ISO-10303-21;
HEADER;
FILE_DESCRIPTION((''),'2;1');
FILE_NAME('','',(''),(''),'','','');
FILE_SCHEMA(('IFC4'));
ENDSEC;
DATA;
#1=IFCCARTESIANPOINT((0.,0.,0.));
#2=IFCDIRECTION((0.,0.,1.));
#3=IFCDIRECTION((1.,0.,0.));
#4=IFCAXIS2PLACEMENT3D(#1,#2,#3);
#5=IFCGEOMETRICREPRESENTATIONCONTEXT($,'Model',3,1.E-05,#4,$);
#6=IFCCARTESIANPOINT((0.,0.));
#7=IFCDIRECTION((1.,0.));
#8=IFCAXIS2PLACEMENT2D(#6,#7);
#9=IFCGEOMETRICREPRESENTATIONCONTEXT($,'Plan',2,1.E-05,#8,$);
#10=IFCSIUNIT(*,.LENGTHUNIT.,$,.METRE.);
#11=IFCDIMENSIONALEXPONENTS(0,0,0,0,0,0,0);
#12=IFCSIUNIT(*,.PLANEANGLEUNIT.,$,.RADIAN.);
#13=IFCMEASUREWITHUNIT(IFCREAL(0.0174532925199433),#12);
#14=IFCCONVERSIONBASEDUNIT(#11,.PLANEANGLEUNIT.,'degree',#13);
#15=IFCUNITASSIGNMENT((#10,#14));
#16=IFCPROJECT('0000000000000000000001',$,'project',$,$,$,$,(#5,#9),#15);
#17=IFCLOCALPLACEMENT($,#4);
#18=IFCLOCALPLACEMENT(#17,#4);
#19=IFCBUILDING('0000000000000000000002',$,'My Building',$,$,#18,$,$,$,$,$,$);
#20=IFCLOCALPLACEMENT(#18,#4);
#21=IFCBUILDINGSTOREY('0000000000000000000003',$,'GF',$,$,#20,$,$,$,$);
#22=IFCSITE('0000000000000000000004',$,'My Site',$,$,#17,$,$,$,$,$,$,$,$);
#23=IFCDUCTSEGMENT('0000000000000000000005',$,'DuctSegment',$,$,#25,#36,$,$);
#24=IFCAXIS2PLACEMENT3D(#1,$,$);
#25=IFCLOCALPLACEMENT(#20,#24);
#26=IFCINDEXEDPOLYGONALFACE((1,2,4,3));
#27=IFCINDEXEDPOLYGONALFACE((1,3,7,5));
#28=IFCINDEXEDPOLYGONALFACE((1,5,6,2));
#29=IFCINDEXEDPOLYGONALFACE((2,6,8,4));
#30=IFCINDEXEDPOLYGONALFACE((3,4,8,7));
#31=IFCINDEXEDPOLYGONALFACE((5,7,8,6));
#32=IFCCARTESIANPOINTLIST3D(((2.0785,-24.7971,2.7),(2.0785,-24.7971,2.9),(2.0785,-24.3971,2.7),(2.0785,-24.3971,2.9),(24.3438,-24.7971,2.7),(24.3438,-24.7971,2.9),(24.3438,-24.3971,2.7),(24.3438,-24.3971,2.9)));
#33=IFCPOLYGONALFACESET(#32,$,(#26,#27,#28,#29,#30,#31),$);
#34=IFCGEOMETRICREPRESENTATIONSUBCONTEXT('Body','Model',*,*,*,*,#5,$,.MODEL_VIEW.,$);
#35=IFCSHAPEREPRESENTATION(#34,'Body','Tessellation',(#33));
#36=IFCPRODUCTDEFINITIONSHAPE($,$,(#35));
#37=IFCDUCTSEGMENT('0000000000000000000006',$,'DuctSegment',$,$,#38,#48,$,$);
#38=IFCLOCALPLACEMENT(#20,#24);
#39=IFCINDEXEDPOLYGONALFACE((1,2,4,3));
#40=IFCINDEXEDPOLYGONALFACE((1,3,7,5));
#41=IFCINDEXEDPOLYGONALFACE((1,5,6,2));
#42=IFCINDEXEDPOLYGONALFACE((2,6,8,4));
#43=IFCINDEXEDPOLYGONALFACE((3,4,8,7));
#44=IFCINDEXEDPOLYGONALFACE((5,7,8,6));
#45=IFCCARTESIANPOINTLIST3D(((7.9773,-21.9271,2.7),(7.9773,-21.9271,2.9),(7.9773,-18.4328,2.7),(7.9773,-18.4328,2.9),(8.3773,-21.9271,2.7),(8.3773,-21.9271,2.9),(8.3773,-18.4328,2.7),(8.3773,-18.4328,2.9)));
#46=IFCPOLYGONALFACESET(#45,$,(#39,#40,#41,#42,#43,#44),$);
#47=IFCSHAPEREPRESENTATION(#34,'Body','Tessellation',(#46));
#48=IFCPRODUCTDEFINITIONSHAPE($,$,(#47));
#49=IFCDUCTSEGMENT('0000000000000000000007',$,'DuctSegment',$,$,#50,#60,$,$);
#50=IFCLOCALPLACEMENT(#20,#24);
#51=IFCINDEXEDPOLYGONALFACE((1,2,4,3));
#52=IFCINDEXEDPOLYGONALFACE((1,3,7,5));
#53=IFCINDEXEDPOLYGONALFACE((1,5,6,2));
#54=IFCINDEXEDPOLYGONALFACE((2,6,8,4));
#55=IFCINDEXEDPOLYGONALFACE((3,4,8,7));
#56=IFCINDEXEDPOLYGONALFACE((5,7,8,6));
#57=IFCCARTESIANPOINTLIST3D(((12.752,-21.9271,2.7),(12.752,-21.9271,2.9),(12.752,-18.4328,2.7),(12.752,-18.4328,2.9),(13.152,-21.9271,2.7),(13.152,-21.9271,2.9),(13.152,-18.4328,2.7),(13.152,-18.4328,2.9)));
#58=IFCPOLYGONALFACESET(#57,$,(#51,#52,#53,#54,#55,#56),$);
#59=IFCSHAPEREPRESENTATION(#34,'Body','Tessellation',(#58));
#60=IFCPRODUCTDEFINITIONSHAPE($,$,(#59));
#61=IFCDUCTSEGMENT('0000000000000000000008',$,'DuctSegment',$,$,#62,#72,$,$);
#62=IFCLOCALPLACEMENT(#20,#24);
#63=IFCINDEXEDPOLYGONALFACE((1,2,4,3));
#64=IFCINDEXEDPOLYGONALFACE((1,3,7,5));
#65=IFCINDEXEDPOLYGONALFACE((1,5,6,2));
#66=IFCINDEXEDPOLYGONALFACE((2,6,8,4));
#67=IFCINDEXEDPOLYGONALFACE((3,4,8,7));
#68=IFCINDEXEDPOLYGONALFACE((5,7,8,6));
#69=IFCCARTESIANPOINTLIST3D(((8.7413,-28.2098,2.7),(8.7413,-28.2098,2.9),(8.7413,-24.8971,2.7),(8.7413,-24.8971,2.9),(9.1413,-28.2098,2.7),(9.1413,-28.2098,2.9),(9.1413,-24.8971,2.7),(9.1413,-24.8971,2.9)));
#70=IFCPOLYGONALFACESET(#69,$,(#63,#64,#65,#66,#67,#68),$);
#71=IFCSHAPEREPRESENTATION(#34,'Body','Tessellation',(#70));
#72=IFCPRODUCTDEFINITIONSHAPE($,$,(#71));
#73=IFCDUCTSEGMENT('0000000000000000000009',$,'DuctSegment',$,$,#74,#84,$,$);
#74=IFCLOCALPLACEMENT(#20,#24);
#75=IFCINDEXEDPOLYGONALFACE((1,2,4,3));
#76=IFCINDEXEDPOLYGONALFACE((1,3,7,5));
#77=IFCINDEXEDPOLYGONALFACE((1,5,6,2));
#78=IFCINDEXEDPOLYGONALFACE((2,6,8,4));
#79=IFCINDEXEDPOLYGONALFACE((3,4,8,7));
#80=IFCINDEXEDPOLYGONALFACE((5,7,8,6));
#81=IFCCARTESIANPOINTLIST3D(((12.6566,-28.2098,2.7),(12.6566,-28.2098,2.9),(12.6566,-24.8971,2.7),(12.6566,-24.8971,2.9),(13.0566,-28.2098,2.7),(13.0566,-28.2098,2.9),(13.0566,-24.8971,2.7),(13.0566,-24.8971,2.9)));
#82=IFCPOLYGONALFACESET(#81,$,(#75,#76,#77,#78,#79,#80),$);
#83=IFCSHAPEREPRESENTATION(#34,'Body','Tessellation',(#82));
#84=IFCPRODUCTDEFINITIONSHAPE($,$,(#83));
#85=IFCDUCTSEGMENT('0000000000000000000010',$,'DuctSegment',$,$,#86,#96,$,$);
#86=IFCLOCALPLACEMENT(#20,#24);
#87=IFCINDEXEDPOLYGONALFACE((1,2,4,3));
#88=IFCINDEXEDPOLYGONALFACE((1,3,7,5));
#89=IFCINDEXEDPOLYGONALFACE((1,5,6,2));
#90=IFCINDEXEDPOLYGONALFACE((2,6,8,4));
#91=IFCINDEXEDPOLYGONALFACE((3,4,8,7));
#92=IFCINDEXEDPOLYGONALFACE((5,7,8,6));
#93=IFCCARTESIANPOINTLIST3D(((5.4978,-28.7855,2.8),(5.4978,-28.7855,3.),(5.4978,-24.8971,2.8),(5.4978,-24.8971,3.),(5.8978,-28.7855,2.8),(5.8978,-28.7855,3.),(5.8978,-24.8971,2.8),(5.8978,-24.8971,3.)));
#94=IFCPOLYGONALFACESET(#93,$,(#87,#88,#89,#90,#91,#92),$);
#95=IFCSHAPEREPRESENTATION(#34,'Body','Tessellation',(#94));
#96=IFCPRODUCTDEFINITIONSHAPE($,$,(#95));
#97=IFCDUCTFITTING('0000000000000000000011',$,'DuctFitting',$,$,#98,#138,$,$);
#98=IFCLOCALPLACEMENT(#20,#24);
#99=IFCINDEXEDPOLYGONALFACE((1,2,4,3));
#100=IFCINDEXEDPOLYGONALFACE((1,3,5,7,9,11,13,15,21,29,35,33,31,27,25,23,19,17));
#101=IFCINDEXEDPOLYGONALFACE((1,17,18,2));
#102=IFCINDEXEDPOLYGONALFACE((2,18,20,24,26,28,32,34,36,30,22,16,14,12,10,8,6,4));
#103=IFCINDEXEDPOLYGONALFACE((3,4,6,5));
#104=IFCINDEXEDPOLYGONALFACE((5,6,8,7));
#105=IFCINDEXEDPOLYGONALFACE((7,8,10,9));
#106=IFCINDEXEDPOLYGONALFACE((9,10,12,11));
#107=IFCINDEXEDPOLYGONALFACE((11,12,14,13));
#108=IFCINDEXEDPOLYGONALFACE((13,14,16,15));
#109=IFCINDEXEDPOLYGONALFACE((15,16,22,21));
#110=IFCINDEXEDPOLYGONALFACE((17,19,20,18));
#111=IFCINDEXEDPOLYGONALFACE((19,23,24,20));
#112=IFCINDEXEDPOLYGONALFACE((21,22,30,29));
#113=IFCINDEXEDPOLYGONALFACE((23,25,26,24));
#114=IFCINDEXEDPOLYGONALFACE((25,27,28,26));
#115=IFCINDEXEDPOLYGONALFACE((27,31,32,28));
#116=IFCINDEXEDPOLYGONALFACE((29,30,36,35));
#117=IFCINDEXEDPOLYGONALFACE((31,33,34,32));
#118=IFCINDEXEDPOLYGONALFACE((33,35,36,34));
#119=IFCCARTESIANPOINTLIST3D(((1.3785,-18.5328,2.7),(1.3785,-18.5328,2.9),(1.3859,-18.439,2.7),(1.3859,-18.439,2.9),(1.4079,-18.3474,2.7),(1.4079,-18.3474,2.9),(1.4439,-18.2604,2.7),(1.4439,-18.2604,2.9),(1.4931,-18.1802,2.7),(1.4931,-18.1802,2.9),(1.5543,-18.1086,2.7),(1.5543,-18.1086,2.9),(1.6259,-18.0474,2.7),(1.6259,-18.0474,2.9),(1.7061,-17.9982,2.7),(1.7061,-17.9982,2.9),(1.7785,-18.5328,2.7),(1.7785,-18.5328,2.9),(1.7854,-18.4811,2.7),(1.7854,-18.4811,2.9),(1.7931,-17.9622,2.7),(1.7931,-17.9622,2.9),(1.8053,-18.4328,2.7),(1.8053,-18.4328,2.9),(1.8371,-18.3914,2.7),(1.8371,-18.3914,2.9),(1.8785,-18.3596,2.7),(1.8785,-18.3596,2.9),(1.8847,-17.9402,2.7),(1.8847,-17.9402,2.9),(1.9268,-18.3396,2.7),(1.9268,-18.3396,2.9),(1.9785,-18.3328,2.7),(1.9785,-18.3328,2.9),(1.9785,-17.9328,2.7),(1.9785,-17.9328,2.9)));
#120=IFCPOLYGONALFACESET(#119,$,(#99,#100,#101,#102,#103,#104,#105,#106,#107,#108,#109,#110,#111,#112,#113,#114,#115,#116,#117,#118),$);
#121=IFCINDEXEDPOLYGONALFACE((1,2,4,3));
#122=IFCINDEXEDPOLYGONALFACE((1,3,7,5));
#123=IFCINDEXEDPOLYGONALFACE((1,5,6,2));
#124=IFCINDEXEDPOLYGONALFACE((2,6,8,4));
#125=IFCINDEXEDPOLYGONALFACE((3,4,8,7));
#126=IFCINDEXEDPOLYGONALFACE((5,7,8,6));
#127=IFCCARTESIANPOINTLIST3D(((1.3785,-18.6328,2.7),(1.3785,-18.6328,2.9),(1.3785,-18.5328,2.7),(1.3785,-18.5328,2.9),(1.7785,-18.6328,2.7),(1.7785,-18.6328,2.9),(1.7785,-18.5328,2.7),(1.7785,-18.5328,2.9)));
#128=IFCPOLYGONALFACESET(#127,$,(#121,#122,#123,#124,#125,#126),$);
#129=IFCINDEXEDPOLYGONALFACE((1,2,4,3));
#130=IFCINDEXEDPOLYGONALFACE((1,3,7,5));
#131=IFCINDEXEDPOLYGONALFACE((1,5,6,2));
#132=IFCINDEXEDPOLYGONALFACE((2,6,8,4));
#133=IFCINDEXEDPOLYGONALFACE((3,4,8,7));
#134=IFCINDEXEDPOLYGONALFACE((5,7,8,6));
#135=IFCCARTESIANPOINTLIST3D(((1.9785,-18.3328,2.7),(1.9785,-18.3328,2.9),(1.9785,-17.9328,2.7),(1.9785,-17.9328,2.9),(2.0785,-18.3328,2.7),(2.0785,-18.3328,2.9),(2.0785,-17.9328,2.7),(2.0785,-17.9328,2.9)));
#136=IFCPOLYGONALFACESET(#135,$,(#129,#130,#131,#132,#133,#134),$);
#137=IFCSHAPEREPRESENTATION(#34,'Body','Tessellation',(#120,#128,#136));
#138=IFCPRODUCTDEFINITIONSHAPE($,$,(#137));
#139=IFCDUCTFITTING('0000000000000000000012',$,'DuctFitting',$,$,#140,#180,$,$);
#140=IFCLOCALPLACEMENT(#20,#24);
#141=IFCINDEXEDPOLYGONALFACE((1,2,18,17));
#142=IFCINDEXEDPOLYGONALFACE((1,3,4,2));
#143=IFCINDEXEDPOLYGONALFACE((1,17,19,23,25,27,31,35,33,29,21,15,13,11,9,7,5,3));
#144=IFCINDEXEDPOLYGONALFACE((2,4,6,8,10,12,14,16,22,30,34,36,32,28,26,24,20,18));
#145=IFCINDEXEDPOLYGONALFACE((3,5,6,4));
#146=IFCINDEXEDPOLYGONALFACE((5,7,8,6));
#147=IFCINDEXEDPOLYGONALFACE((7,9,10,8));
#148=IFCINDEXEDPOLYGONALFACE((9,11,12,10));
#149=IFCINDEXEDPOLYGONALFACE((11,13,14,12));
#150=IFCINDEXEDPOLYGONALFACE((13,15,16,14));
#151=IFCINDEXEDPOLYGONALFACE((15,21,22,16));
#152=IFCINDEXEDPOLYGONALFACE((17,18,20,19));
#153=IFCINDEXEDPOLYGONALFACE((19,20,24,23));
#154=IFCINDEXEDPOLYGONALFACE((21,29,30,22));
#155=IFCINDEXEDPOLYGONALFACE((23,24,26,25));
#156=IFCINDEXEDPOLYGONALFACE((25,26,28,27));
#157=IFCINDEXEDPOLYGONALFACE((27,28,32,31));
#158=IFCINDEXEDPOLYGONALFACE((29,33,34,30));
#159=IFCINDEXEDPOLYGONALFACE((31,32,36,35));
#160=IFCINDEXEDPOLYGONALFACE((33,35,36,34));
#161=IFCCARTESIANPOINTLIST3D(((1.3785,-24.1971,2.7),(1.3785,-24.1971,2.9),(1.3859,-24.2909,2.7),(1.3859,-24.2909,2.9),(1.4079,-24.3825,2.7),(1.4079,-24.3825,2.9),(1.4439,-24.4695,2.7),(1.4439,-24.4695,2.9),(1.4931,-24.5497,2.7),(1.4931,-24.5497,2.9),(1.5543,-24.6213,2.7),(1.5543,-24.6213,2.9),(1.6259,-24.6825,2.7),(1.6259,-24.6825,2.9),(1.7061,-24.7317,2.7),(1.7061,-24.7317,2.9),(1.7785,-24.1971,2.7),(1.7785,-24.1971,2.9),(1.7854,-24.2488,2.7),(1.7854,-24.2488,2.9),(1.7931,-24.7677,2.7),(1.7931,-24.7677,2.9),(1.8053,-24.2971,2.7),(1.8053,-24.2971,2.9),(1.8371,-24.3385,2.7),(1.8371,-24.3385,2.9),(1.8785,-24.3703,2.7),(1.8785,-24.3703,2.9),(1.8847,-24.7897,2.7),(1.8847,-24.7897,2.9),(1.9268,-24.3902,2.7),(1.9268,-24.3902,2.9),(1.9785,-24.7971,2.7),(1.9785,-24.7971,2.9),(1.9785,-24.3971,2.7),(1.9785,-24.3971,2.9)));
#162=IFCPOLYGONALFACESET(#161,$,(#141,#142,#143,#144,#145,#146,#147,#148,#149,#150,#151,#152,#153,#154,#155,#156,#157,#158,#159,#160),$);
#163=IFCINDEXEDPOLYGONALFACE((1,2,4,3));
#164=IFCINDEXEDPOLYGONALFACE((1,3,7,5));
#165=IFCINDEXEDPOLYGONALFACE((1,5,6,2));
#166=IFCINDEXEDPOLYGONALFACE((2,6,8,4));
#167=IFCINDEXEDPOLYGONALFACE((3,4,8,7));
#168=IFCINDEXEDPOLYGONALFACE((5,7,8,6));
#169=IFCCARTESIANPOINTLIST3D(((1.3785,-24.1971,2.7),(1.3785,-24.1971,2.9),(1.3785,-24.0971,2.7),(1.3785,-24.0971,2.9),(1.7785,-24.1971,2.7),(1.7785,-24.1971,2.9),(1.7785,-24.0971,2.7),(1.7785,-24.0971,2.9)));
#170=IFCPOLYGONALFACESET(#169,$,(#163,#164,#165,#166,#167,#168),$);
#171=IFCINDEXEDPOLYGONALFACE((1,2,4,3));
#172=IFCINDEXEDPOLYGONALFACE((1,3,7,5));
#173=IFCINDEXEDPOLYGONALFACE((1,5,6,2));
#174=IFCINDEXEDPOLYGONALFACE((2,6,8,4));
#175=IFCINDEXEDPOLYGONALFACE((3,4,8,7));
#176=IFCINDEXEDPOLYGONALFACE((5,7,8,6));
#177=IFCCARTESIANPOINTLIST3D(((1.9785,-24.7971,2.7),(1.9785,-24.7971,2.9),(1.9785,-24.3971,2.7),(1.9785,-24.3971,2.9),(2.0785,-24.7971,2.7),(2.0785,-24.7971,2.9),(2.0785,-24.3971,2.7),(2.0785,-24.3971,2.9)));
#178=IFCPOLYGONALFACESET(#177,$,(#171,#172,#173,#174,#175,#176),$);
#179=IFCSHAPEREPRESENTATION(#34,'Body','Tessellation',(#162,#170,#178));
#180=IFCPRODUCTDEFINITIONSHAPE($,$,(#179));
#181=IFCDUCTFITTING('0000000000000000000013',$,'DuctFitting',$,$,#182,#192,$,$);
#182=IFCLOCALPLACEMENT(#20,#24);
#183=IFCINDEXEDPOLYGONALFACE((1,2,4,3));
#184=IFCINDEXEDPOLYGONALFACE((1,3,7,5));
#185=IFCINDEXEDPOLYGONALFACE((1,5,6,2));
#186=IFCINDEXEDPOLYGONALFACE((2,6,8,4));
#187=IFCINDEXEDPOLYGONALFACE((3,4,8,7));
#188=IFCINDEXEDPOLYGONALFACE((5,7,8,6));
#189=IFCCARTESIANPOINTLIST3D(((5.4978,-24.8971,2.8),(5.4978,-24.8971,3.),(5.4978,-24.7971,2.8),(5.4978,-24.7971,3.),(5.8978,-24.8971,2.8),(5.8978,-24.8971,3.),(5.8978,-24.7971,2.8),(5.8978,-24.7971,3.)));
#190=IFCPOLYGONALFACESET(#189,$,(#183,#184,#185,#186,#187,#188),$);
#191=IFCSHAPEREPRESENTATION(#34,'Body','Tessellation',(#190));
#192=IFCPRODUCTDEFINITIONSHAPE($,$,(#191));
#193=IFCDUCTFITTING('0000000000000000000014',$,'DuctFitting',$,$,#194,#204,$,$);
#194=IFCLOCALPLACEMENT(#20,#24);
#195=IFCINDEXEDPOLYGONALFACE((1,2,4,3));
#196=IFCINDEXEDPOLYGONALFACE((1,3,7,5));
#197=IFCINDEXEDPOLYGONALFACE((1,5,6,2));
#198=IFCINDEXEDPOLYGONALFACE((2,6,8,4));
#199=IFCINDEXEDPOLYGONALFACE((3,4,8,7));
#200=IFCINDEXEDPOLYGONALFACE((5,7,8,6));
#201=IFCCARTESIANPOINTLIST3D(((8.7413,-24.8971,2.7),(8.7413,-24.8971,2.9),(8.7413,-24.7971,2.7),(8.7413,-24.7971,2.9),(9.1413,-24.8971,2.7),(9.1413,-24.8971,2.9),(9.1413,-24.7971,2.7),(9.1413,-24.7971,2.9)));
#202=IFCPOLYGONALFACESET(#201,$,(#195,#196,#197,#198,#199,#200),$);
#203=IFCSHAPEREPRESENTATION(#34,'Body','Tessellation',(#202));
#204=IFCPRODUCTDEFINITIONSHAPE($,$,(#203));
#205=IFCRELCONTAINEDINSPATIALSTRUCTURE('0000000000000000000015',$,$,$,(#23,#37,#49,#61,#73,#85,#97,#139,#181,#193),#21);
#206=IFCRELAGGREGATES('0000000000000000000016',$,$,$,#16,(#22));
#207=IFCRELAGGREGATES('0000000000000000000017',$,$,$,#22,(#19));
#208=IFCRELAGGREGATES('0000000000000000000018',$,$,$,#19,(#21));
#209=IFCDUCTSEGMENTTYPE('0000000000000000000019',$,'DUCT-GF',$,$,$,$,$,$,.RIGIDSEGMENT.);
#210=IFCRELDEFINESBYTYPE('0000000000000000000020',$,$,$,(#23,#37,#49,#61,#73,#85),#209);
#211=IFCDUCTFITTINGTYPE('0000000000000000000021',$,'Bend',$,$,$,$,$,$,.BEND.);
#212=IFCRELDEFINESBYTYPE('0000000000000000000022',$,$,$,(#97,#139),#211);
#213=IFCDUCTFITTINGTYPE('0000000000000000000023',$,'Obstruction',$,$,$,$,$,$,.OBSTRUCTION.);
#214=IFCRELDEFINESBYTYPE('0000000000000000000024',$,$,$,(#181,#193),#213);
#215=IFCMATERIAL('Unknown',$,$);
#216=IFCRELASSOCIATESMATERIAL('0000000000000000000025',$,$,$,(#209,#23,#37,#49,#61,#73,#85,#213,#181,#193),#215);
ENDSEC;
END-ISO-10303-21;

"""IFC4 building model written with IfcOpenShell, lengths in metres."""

from ifc_helpers import new_model, entity, si_unit, converted_unit, frame, origin_with_axes, origin_2d_with_axis, place, context, subcontext, project, spatial, line, arc, indexed_curve, rectangle, outline, extrude, source, transform, mapped, material, material_profile, profile_set, profile_usage, type_object, type_shapes, element, save


model = new_model("IFC4")

# Units and contexts
model_context = context("Model", 3, precision=1e-05, world=origin_with_axes())
plan_context = context("Plan", 2, precision=1e-05, world=origin_2d_with_axis())
body_context_1 = subcontext(model_context, "Body", "Model", "MODEL_VIEW")
ifc_project = project(units=[si_unit("LENGTHUNIT", "METRE"), converted_unit("PLANEANGLEUNIT", "degree", entity("IfcReal", 0.0174532925199433), si_unit("PLANEANGLEUNIT", "RADIAN"), dimensions=[0, 0, 0, 0, 0, 0, 0])], contexts=[model_context, plan_context])

# Site, building, storey
site_placement = place(None, origin_with_axes())
site = spatial("IfcSite", under=ifc_project, at=site_placement, Name="My Site")
building_placement = place(site_placement, origin_with_axes())
building = spatial("IfcBuilding", under=site, at=building_placement, Name="My Building")
storey_placement = place(building_placement, origin_with_axes())
storey = spatial("IfcBuildingStorey", under=building, at=storey_placement, Name="GF")

# Shared definitions
ifc_material = material(Name="Unknown")

# Duct segments
ifc_material_profile_1 = material_profile(ifc_material, rectangle(XDim=0.4, YDim=0.2))
ifc_profile_set_1 = profile_set([ifc_material_profile_1])
duct_segment_type = type_object("IfcDuctSegmentType", Name="DUCT-GF", PredefinedType="RIGIDSEGMENT", material=ifc_profile_set_1)
ifc_profile_usage_1 = profile_usage(ifc_profile_set_1, cardinal=5)
duct_segment_1_placement = place(storey_placement, frame((2.0785, -24.5971, 2.8), z_axis=(1.0, 0.0, 0.0), x_axis=(0.0, 1.0, 0.0)))
element("IfcDuctSegment", 1, at=duct_segment_1_placement, inside=storey, type_object=duct_segment_type, material=ifc_profile_usage_1, Name="DuctSegment", context=body_context_1, shape_type="SweptSolid", body=[
    extrude(rectangle(XDim=0.4, YDim=0.2), origin_with_axes(), (0.0, 0.0, 1.0), 22.2653),
])
ifc_profile_usage_2 = profile_usage(ifc_profile_set_1, cardinal=5)
duct_segment_2_placement = place(storey_placement, frame((8.1773, -18.4328, 2.8), z_axis=(0.0, -1.0, 0.0), x_axis=(1.0, 0.0, 0.0)))
element("IfcDuctSegment", 2, at=duct_segment_2_placement, inside=storey, type_object=duct_segment_type, material=ifc_profile_usage_2, Name="DuctSegment", context=body_context_1, shape_type="SweptSolid", body=[
    extrude(rectangle(XDim=0.4, YDim=0.2), origin_with_axes(), (0.0, 0.0, 1.0), 3.4943),
])
ifc_profile_usage_3 = profile_usage(ifc_profile_set_1, cardinal=5)
duct_segment_3_placement = place(storey_placement, frame((12.952, -18.4328, 2.8), z_axis=(0.0, -1.0, 0.0), x_axis=(1.0, 0.0, 0.0)))
element("IfcDuctSegment", 3, at=duct_segment_3_placement, inside=storey, type_object=duct_segment_type, material=ifc_profile_usage_3, Name="DuctSegment", context=body_context_1, shape_type="SweptSolid", body=[
    extrude(rectangle(XDim=0.4, YDim=0.2), origin_with_axes(), (0.0, 0.0, 1.0), 3.4943),
])
ifc_profile_usage_4 = profile_usage(ifc_profile_set_1, cardinal=5)
duct_segment_4_placement = place(storey_placement, frame((8.9413, -24.8971, 2.8), z_axis=(0.0, -1.0, 0.0), x_axis=(1.0, 0.0, 0.0)))
element("IfcDuctSegment", 4, at=duct_segment_4_placement, inside=storey, type_object=duct_segment_type, material=ifc_profile_usage_4, Name="DuctSegment", context=body_context_1, shape_type="SweptSolid", body=[
    extrude(rectangle(XDim=0.4, YDim=0.2), origin_with_axes(), (0.0, 0.0, 1.0), 3.3127),
])
ifc_profile_usage_5 = profile_usage(ifc_profile_set_1, cardinal=5)
duct_segment_5_placement = place(storey_placement, frame((12.8566, -24.8971, 2.8), z_axis=(0.0, -1.0, 0.0), x_axis=(1.0, 0.0, 0.0)))
element("IfcDuctSegment", 5, at=duct_segment_5_placement, inside=storey, type_object=duct_segment_type, material=ifc_profile_usage_5, Name="DuctSegment", context=body_context_1, shape_type="SweptSolid", body=[
    extrude(rectangle(XDim=0.4, YDim=0.2), origin_with_axes(), (0.0, 0.0, 1.0), 3.3127),
])
ifc_profile_usage_6 = profile_usage(ifc_profile_set_1, cardinal=5)
duct_segment_6_placement = place(storey_placement, frame((5.6978, -24.8971, 2.9), z_axis=(0.0, -1.0, 0.0), x_axis=(1.0, 0.0, 0.0)))
element("IfcDuctSegment", 6, at=duct_segment_6_placement, inside=storey, type_object=duct_segment_type, material=ifc_profile_usage_6, Name="DuctSegment", context=body_context_1, shape_type="SweptSolid", body=[
    extrude(rectangle(XDim=0.4, YDim=0.2), origin_with_axes(), (0.0, 0.0, 1.0), 3.8885),
])

# Duct fittings
duct_fitting_type_1 = type_object("IfcDuctFittingType", Name="Bend", PredefinedType="BEND")
shared_shape_1 = source(origin_with_axes(), body_context_1, "Body", "SweptSolid", [
    extrude(outline(indexed_curve([(0.2, 0.0), (0.2586, -0.1414), (0.4, -0.2), (0.4, -0.6), (-0.0243, -0.4243), (-0.2, 0.0)], segments=[arc(1, 2, 3), line(3, 4), arc(4, 5, 6), line(6, 1)])), frame((0.0, -0.1, -0.1), z_axis=(0.0, -1.0, 0.0), x_axis=(1.0, 0.0, 0.0)), (0.0, 0.0, -1.0), 0.2),
    extrude(rectangle(XDim=0.4, YDim=0.2), origin_with_axes(), (0.0, 0.0, -1.0), 0.1),
    extrude(rectangle(XDim=0.4, YDim=0.2), frame((0.4, 0.0, -0.5), z_axis=(1.0, 0.0, 0.0), x_axis=(0.0, 0.0, 1.0)), (0.0, 0.0, 1.0), 0.1),
])
type_shapes(duct_fitting_type_1, [shared_shape_1])
for number, where, z_axis, x_axis, name in (
    (7, (1.5785, -18.6328, 2.8), (0.0, -1.0, 0.0), (1.0, 0.0, 0.0), "DuctFitting"),
    (8, (1.5785, -24.0971, 2.8), (0.0, 1.0, 0.0), (1.0, 0.0, 0.0), "DuctFitting"),
):
    element("IfcDuctFitting", number, at=place(storey_placement, frame(where, z_axis=z_axis, x_axis=x_axis)), inside=storey, type_object=duct_fitting_type_1, Name=name, context=body_context_1, shape_type="MappedRepresentation", body=[
        mapped(shared_shape_1, transform((0.0, 0.0, 0.0), x_axis=(1.0, 0.0, 0.0), y_axis=(0.0, 1.0, 0.0), z_axis=(0.0, 0.0, 1.0), scale=1.0)),
    ])
ifc_material_profile_2 = material_profile(ifc_material, rectangle(XDim=0.4, YDim=0.2))
ifc_profile_set_2 = profile_set([ifc_material_profile_2])
ifc_profile_usage_7 = profile_usage(ifc_profile_set_2, cardinal=5)
duct_fitting_type_2 = type_object("IfcDuctFittingType", Name="Obstruction", PredefinedType="OBSTRUCTION", material=ifc_profile_set_2)
duct_fitting_1_placement = place(storey_placement, frame((5.6978, -24.7971, 2.9), z_axis=(0.0, -1.0, 0.0), x_axis=(1.0, 0.0, 0.0)))
element("IfcDuctFitting", 9, at=duct_fitting_1_placement, inside=storey, type_object=duct_fitting_type_2, material=ifc_profile_usage_7, Name="DuctFitting", context=body_context_1, shape_type="SweptSolid", body=[
    extrude(rectangle(XDim=0.4, YDim=0.2), origin_with_axes(), (0.0, 0.0, 1.0), 0.1),
])
ifc_profile_usage_8 = profile_usage(ifc_profile_set_2, cardinal=5)
duct_fitting_2_placement = place(storey_placement, frame((8.9413, -24.7971, 2.8), z_axis=(0.0, -1.0, 0.0), x_axis=(1.0, 0.0, 0.0)))
element("IfcDuctFitting", 10, at=duct_fitting_2_placement, inside=storey, type_object=duct_fitting_type_2, material=ifc_profile_usage_8, Name="DuctFitting", context=body_context_1, shape_type="SweptSolid", body=[
    extrude(rectangle(XDim=0.4, YDim=0.2), origin_with_axes(), (0.0, 0.0, 1.0), 0.1),
])

save(model, "model.ifc")
